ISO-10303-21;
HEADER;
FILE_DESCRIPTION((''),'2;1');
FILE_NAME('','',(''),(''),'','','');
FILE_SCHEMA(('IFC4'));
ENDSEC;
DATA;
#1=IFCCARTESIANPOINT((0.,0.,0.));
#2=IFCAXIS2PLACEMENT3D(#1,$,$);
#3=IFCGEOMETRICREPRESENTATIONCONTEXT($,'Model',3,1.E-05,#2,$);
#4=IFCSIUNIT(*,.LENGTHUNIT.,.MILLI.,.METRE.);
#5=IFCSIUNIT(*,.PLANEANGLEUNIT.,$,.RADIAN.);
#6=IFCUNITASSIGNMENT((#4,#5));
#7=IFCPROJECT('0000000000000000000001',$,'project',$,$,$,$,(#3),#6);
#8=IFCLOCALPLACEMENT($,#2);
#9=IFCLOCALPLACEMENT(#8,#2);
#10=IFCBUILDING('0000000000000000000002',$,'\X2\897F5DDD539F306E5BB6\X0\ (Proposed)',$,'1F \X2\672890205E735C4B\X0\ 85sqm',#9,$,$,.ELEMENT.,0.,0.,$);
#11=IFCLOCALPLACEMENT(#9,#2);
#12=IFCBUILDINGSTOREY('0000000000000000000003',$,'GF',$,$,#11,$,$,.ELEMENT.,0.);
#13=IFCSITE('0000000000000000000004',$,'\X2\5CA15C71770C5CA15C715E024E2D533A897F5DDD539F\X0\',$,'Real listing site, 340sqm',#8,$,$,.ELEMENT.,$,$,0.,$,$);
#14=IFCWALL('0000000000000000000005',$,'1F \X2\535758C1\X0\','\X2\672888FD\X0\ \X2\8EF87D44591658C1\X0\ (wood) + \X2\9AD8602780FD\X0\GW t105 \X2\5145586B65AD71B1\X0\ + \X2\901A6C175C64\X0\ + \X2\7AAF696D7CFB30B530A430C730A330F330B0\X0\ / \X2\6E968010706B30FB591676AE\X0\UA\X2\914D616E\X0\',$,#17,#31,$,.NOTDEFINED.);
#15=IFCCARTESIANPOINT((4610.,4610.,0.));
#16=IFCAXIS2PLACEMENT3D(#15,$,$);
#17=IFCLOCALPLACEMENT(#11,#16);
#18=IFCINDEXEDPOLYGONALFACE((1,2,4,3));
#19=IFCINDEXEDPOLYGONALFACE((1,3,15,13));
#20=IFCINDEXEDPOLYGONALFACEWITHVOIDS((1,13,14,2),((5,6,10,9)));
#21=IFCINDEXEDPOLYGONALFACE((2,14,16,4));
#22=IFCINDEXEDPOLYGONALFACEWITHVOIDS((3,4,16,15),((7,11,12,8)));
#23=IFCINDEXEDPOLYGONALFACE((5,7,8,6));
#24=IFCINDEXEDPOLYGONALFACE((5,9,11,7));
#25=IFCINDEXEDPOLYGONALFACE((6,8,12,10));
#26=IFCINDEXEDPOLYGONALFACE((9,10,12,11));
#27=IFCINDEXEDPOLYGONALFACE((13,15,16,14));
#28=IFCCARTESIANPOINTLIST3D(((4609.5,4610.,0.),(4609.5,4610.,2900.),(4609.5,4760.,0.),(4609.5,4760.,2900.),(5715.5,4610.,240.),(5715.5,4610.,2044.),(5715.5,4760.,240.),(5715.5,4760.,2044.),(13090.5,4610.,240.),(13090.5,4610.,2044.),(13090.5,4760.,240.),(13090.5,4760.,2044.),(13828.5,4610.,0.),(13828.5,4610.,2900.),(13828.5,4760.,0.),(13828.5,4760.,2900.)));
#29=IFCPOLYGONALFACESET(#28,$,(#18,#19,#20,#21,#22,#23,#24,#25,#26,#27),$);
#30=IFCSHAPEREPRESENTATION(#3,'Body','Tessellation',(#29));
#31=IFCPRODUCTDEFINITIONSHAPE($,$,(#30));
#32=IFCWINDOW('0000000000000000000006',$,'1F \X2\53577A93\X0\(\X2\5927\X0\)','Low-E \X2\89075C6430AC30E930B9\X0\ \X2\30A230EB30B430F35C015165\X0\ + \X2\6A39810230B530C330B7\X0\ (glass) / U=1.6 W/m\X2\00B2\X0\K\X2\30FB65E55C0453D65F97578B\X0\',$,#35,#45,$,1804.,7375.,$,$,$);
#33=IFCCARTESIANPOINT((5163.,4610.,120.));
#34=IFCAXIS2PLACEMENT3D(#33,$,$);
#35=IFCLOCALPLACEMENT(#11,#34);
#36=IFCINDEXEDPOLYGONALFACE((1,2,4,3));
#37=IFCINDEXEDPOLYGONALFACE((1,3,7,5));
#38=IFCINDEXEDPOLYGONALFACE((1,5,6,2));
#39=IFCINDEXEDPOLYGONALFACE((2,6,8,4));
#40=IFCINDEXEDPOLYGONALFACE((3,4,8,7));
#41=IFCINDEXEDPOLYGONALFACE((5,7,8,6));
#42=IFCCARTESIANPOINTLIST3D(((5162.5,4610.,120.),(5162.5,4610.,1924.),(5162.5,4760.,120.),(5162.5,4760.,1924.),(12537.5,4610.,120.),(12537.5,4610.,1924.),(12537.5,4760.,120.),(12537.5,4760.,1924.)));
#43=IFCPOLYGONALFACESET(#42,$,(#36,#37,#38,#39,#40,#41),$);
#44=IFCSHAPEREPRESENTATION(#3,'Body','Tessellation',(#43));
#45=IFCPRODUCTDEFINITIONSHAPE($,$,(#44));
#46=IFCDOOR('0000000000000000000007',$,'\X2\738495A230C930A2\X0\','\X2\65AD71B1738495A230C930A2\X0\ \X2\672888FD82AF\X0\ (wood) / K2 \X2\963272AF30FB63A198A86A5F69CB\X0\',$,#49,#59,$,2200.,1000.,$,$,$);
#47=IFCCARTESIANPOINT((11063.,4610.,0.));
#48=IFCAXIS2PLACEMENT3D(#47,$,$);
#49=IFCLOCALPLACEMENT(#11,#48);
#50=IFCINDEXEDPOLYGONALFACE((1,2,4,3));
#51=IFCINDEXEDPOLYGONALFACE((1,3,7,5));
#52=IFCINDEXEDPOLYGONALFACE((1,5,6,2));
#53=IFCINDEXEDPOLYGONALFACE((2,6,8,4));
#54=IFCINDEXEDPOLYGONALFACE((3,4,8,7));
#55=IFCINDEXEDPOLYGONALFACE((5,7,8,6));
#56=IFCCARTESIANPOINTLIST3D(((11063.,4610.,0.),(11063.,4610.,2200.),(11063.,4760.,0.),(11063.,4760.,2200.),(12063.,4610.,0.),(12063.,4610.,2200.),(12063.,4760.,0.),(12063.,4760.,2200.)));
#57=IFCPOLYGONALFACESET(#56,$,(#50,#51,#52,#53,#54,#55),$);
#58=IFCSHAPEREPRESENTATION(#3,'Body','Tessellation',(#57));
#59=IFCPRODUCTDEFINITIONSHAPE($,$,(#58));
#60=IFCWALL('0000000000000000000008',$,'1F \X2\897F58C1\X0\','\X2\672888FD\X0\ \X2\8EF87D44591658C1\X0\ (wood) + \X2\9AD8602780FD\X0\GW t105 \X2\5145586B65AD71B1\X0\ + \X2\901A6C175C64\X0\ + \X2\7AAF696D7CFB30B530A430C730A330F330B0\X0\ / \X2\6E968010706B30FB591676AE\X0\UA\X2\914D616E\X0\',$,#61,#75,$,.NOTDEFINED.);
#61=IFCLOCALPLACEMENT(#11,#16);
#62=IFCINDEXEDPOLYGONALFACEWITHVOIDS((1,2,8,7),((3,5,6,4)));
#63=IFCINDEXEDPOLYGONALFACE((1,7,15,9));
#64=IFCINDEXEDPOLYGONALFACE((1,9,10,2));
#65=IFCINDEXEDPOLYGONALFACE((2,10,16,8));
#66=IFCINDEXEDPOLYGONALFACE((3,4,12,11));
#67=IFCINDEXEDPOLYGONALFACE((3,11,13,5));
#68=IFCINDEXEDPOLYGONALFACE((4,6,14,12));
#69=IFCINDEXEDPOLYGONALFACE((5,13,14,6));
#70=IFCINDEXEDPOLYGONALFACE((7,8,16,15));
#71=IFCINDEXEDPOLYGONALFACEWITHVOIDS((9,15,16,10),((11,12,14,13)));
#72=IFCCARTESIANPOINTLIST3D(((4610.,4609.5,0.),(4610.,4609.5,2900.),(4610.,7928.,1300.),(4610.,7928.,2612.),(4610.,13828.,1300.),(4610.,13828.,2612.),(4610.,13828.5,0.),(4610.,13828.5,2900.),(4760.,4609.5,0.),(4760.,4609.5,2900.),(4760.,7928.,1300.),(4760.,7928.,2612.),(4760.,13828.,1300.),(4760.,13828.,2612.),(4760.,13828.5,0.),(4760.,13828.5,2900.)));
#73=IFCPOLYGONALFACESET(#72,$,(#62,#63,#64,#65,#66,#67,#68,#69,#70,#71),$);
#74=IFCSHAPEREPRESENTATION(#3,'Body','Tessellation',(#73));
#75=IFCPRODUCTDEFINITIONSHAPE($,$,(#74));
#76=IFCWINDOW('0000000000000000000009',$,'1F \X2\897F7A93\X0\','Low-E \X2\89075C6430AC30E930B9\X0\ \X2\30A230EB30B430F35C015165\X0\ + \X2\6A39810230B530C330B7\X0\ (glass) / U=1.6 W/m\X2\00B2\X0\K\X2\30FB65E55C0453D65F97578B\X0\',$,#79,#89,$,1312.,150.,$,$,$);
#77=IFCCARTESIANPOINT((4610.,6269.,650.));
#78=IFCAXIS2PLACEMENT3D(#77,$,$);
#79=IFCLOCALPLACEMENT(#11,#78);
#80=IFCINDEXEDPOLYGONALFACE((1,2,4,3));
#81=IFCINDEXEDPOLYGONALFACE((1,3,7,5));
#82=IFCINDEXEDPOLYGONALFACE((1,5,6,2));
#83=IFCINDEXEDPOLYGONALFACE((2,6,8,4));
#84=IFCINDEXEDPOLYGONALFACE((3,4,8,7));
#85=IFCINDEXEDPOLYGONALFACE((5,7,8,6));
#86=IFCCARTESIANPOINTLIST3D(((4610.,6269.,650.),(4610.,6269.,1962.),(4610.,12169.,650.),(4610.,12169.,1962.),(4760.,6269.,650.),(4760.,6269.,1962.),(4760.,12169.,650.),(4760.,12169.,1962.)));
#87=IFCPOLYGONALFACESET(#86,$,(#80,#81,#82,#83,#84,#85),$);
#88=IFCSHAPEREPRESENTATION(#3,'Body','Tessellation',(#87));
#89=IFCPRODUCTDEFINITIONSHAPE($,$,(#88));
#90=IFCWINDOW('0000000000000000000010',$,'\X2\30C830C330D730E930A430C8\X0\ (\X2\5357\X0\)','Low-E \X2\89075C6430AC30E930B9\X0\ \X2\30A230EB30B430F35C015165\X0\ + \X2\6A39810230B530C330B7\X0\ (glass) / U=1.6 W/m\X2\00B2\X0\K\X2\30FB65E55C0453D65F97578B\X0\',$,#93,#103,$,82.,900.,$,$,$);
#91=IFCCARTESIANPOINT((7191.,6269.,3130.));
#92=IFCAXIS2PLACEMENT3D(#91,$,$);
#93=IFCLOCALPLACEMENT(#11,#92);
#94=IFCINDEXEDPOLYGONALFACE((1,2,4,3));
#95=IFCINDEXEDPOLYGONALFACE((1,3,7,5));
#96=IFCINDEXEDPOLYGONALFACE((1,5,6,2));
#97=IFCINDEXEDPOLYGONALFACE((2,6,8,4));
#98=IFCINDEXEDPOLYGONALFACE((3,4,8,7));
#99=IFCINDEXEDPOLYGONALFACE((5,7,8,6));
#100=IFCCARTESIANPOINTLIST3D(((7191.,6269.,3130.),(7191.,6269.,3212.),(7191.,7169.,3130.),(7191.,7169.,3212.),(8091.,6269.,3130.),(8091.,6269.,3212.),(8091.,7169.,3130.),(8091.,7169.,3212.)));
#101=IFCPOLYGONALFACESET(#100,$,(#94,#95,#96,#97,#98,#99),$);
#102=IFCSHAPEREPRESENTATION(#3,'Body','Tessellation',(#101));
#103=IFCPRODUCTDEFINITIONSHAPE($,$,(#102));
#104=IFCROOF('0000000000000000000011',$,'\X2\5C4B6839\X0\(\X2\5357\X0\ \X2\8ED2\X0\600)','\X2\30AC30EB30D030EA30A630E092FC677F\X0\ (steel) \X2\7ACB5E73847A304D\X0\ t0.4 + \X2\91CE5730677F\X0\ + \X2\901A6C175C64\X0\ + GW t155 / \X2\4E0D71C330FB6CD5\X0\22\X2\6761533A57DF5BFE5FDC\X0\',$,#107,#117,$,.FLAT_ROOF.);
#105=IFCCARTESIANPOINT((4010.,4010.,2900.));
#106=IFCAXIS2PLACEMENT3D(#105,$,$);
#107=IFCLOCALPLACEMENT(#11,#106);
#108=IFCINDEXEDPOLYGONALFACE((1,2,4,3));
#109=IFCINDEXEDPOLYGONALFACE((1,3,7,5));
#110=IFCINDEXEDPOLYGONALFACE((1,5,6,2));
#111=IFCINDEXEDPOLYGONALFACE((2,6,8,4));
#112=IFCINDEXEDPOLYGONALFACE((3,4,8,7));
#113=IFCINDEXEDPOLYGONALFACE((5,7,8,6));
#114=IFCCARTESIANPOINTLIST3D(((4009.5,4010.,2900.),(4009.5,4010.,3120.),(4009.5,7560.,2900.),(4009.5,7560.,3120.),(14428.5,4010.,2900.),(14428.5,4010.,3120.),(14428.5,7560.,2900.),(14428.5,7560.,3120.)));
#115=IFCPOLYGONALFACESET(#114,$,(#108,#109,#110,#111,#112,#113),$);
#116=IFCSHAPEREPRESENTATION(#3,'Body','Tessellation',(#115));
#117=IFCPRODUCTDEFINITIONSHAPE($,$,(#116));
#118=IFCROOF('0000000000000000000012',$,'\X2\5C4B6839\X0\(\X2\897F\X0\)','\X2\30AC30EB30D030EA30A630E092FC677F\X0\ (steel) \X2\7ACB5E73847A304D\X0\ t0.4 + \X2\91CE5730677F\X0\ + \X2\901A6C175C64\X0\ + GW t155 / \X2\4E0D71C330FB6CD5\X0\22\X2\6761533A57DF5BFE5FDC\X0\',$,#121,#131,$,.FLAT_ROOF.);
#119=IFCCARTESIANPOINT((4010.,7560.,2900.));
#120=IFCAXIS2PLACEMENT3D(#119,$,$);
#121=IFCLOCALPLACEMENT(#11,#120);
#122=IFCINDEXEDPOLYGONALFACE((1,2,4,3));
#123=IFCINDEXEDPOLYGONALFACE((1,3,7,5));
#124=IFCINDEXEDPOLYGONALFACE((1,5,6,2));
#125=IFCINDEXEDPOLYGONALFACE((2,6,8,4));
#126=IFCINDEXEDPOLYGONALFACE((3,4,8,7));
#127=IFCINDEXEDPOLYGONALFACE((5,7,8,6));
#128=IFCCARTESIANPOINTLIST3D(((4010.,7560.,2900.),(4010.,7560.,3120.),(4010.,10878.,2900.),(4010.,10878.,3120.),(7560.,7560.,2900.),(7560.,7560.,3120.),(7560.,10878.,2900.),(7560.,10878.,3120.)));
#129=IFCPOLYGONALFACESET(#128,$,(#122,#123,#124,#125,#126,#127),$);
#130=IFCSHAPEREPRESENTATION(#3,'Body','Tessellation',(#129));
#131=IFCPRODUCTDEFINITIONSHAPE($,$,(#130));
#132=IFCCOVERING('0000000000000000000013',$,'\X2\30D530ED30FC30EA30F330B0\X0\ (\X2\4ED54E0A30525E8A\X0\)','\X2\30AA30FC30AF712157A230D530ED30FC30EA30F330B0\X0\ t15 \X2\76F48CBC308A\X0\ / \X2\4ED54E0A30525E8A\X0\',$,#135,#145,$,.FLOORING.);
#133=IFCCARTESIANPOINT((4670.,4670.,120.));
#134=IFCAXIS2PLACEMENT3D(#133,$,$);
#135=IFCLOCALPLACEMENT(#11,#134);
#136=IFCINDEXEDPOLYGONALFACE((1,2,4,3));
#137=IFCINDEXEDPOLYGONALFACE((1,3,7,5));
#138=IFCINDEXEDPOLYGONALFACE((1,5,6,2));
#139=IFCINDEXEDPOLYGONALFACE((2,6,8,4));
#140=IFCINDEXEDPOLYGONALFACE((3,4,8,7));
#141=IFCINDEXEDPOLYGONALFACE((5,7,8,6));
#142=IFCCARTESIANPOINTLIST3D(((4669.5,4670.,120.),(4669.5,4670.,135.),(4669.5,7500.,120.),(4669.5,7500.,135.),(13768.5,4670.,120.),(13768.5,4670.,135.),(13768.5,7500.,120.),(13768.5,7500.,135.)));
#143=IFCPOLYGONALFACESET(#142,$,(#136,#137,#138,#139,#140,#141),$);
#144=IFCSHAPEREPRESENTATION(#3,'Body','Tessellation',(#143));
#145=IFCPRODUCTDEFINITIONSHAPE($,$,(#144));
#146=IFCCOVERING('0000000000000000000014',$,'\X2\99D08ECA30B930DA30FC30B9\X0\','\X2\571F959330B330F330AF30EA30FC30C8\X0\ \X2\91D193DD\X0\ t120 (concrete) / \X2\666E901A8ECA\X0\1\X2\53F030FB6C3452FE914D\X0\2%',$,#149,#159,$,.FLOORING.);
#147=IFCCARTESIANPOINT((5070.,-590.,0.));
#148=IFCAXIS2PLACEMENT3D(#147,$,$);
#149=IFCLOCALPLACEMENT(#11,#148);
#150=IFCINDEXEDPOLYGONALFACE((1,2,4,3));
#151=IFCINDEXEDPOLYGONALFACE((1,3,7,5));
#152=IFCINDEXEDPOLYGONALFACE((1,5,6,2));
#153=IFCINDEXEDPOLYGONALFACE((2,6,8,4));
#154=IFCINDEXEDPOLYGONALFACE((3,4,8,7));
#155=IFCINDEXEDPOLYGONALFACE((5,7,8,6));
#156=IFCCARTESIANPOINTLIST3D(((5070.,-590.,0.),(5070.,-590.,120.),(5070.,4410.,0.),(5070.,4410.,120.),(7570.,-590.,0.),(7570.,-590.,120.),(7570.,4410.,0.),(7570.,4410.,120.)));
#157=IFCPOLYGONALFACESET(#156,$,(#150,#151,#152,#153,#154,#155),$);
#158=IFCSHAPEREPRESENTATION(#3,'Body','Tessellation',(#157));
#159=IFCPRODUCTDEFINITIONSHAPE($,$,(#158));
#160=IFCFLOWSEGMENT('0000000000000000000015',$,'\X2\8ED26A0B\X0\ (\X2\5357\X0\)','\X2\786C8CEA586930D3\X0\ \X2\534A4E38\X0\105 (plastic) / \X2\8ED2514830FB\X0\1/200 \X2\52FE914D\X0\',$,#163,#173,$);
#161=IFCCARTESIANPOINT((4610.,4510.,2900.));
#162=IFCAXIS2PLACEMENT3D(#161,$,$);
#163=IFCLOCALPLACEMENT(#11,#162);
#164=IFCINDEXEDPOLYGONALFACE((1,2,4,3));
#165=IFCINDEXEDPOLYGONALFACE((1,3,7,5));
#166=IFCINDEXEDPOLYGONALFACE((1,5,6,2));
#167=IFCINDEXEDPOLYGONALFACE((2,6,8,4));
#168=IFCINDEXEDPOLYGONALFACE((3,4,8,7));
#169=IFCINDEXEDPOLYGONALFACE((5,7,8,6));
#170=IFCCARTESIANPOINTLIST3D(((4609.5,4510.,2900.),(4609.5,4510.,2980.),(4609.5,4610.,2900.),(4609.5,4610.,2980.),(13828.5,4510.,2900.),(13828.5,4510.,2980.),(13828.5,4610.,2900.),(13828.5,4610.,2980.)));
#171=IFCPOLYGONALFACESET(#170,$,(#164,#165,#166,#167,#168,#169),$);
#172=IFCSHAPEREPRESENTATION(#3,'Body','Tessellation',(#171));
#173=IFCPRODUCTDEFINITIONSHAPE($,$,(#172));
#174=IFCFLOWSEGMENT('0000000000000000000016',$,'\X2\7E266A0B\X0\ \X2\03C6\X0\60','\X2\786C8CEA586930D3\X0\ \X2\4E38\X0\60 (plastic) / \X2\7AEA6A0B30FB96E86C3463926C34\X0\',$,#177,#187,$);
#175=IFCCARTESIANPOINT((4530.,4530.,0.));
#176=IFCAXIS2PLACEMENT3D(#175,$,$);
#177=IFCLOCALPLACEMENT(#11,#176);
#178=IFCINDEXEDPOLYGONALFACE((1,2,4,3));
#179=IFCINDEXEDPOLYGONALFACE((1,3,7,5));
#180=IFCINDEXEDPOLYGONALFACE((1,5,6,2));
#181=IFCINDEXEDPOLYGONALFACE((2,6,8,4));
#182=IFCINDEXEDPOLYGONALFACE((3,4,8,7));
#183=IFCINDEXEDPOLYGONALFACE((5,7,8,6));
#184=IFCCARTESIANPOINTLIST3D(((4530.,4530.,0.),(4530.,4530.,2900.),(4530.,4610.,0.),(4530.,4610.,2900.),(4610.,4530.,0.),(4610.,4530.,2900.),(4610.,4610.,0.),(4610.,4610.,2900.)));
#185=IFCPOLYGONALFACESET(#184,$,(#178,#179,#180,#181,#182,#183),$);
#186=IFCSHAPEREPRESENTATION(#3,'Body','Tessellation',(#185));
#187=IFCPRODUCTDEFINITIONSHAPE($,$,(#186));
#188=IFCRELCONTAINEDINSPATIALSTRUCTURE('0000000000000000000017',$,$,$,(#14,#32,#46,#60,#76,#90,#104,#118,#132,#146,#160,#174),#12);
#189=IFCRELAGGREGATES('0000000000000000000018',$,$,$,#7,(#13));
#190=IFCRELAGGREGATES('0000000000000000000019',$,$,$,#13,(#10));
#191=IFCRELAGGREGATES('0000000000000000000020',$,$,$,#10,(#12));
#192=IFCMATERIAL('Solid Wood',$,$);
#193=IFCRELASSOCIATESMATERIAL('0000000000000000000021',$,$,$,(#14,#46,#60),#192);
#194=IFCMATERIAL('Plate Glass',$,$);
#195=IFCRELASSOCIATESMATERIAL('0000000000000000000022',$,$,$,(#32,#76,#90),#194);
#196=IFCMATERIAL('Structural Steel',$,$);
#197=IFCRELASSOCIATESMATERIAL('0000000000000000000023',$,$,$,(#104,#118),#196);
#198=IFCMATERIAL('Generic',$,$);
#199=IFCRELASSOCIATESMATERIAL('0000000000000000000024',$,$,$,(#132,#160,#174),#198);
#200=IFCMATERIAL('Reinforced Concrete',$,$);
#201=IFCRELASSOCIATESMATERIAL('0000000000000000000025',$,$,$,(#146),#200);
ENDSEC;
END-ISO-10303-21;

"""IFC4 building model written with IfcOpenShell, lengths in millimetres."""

from ifc_helpers import new_model, si_unit, frame, frame_2d, origin, place, context, project, spatial, rectangle, extrude, material, element, fill, save


model = new_model("IFC4")

# Units and contexts
model_context = context("Model", 3, precision=1e-05, world=origin())
ifc_project = project(units=[si_unit("LENGTHUNIT", "METRE", prefix="MILLI"), si_unit("PLANEANGLEUNIT", "RADIAN")], contexts=[model_context])

# Site, building, storey
site_placement = place(None, origin())
site = spatial("IfcSite", under=ifc_project, at=site_placement, Name="岡山県岡山市中区西川原", ObjectType="Real listing site, 340sqm", CompositionType="ELEMENT", RefElevation=0.0)
building_placement = place(site_placement, origin())
building = spatial("IfcBuilding", under=site, at=building_placement, Name="西川原の家 (Proposed)", ObjectType="1F 木造平屋 85sqm", CompositionType="ELEMENT", ElevationOfRefHeight=0.0, ElevationOfTerrain=0.0)
storey_placement = place(building_placement, origin())
storey = spatial("IfcBuildingStorey", under=building, at=storey_placement, Name="GF", CompositionType="ELEMENT", Elevation=0.0)

# Shared definitions
ifc_material_1 = material(Name="Solid Wood")

# Shared definitions
ifc_material_2 = material(Name="Reinforced Concrete")

# Wall, openings, window, door
wall_1_placement = place(storey_placement, frame((4610.0, 4610.0, 0.0)))
wall_1 = element("IfcWall", 1, at=wall_1_placement, inside=storey, material=ifc_material_1, Name="1F 南壁", Description="木製 軸組外壁 (wood) + 高性能GW t105 充填断熱 + 通気層 + 窯業系サイディング / 準耐火・外皮UA配慮", PredefinedType="NOTDEFINED", context=model_context, shape_type="SweptSolid", body=[
    extrude(rectangle(XDim=9219.0, YDim=150.0, at=frame_2d((4609.0, 75.0))), frame((4610.0, 4610.0, 0.0)), (0.0, 0.0, 1.0), 2900.0),
])
opening_1_placement = place(storey_placement, frame((5163.0, 4610.0, 120.0)))
opening_1 = element("IfcOpeningElement", 2, at=opening_1_placement, cuts=wall_1, PredefinedType="NOTDEFINED", context=model_context, shape_type="SweptSolid", body=[
    extrude(rectangle(XDim=7375.0, YDim=150.0, at=frame_2d((3687.0, 75.0))), frame((5163.0, 4610.0, 120.0)), (0.0, 0.0, 1.0), 1804.0),
])
opening_2_placement = place(storey_placement, frame((11063.0, 4610.0, 0.0)))
opening_2 = element("IfcOpeningElement", 3, at=opening_2_placement, cuts=wall_1, PredefinedType="NOTDEFINED", context=model_context, shape_type="SweptSolid", body=[
    extrude(rectangle(XDim=1000.0, YDim=150.0, at=frame_2d((500.0, 75.0))), frame((11063.0, 4610.0, 0.0)), (0.0, 0.0, 1.0), 2200.0),
])
ifc_material_3 = material(Name="Plate Glass")
window_1_placement = place(storey_placement, frame((5163.0, 4610.0, 120.0)))
window_1 = element("IfcWindow", 4, at=window_1_placement, inside=storey, material=ifc_material_3, Name="1F 南窓(大)", Description="Low-E 複層ガラス アルゴン封入 + 樹脂サッシ (glass) / U=1.6 W/m²K・日射取得型", OverallHeight=1804.0, OverallWidth=7375.0, context=model_context, shape_type="SweptSolid", body=[
    extrude(rectangle(XDim=7375.0, YDim=150.0, at=frame_2d((3687.0, 75.0))), frame((5163.0, 4610.0, 120.0)), (0.0, 0.0, 1.0), 1804.0),
])
fill(opening_1, window_1)
door_placement = place(storey_placement, frame((11063.0, 4610.0, 0.0)))
door = element("IfcDoor", 5, at=door_placement, inside=storey, material=ifc_material_1, Name="玄関ドア", Description="断熱玄関ドア 木製芯 (wood) / K2 防犯・採風機構", OverallHeight=2200.0, OverallWidth=1000.0, context=model_context, shape_type="SweptSolid", body=[
    extrude(rectangle(XDim=1000.0, YDim=150.0, at=frame_2d((500.0, 75.0))), frame((11063.0, 4610.0, 0.0)), (0.0, 0.0, 1.0), 2200.0),
])
fill(opening_2, door)

# Wall, opening, window
wall_2_placement = place(storey_placement, frame((4610.0, 4610.0, 0.0)))
wall_2 = element("IfcWall", 6, at=wall_2_placement, inside=storey, material=ifc_material_1, Name="1F 西壁", Description="木製 軸組外壁 (wood) + 高性能GW t105 充填断熱 + 通気層 + 窯業系サイディング / 準耐火・外皮UA配慮", PredefinedType="NOTDEFINED", context=model_context, shape_type="SweptSolid", body=[
    extrude(rectangle(XDim=150.0, YDim=9219.0, at=frame_2d((75.0, 4609.0))), frame((4610.0, 4610.0, 0.0)), (0.0, 0.0, 1.0), 2900.0),
])
opening_3_placement = place(storey_placement, frame((4610.0, 6269.0, 650.0)))
opening_3 = element("IfcOpeningElement", 7, at=opening_3_placement, cuts=wall_2, PredefinedType="NOTDEFINED", context=model_context, shape_type="SweptSolid", body=[
    extrude(rectangle(XDim=150.0, YDim=5900.0, at=frame_2d((75.0, 2950.0))), frame((4610.0, 6269.0, 650.0)), (0.0, 0.0, 1.0), 1312.0),
])
window_2_placement = place(storey_placement, frame((4610.0, 6269.0, 650.0)))
window_2 = element("IfcWindow", 8, at=window_2_placement, inside=storey, material=ifc_material_3, Name="1F 西窓", Description="Low-E 複層ガラス アルゴン封入 + 樹脂サッシ (glass) / U=1.6 W/m²K・日射取得型", OverallHeight=1312.0, OverallWidth=150.0, context=model_context, shape_type="SweptSolid", body=[
    extrude(rectangle(XDim=150.0, YDim=5900.0, at=frame_2d((75.0, 2950.0))), frame((4610.0, 6269.0, 650.0)), (0.0, 0.0, 1.0), 1312.0),
])
fill(opening_3, window_2)

# Window
window_3_placement = place(storey_placement, frame((7191.0, 6269.0, 3130.0)))
element("IfcWindow", 9, at=window_3_placement, inside=storey, material=ifc_material_3, Name="トップライト (南)", Description="Low-E 複層ガラス アルゴン封入 + 樹脂サッシ (glass) / U=1.6 W/m²K・日射取得型", OverallHeight=82.0, OverallWidth=900.0, context=model_context, shape_type="SweptSolid", body=[
    extrude(rectangle(XDim=900.0, YDim=900.0, at=frame_2d((450.0, 450.0))), frame((7191.0, 6269.0, 3130.0)), (0.0, 0.0, 1.0), 82.0),
])

# Roofs
ifc_material_4 = material(Name="Structural Steel")
roof_1_placement = place(storey_placement, frame((4010.0, 4010.0, 2900.0)))
element("IfcRoof", 10, at=roof_1_placement, inside=storey, material=ifc_material_4, Name="屋根(南 軒600)", Description="ガルバリウム鋼板 (steel) 立平葺き t0.4 + 野地板 + 通気層 + GW t155 / 不燃・法22条区域対応", PredefinedType="FLAT_ROOF", context=model_context, shape_type="SweptSolid", body=[
    extrude(rectangle(XDim=10419.0, YDim=3550.0, at=frame_2d((5209.0, 1775.0))), frame((4010.0, 4010.0, 2900.0)), (0.0, 0.0, 1.0), 220.0),
])
roof_2_placement = place(storey_placement, frame((4010.0, 7560.0, 2900.0)))
element("IfcRoof", 11, at=roof_2_placement, inside=storey, material=ifc_material_4, Name="屋根(西)", Description="ガルバリウム鋼板 (steel) 立平葺き t0.4 + 野地板 + 通気層 + GW t155 / 不燃・法22条区域対応", PredefinedType="FLAT_ROOF", context=model_context, shape_type="SweptSolid", body=[
    extrude(rectangle(XDim=3550.0, YDim=3318.0, at=frame_2d((1775.0, 1659.0))), frame((4010.0, 7560.0, 2900.0)), (0.0, 0.0, 1.0), 220.0),
])

# Coverings
ifc_material_5 = material(Name="Generic")
covering_1_placement = place(storey_placement, frame((4670.0, 4670.0, 120.0)))
element("IfcCovering", 12, at=covering_1_placement, inside=storey, material=ifc_material_5, Name="フローリング (仕上げ床)", Description="オーク無垢フローリング t15 直貼り / 仕上げ床", PredefinedType="FLOORING", context=model_context, shape_type="SweptSolid", body=[
    extrude(rectangle(XDim=9099.0, YDim=2830.0, at=frame_2d((4549.0, 1415.0))), frame((4670.0, 4670.0, 120.0)), (0.0, 0.0, 1.0), 15.0),
])
covering_2_placement = place(storey_placement, frame((5070.0, -590.0, 0.0)))
element("IfcCovering", 13, at=covering_2_placement, inside=storey, material=ifc_material_2, Name="駐車スペース", Description="土間コンクリート 金鏝 t120 (concrete) / 普通車1台・水勾配2%", PredefinedType="FLOORING", context=model_context, shape_type="SweptSolid", body=[
    extrude(rectangle(XDim=2500.0, YDim=5000.0, at=frame_2d((1250.0, 2500.0))), frame((5070.0, -590.0, 0.0)), (0.0, 0.0, 1.0), 120.0),
])

# Flow segments
flow_segment_1_placement = place(storey_placement, frame((4610.0, 4510.0, 2900.0)))
element("IfcFlowSegment", 14, at=flow_segment_1_placement, inside=storey, material=ifc_material_5, Name="軒樋 (南)", Description="硬質塩ビ 半丸105 (plastic) / 軒先・1/200 勾配", context=model_context, shape_type="SweptSolid", body=[
    extrude(rectangle(XDim=9219.0, YDim=100.0, at=frame_2d((4609.0, 50.0))), frame((4610.0, 4510.0, 2900.0)), (0.0, 0.0, 1.0), 80.0),
])
flow_segment_2_placement = place(storey_placement, frame((4530.0, 4530.0, 0.0)))
element("IfcFlowSegment", 15, at=flow_segment_2_placement, inside=storey, material=ifc_material_5, Name="縦樋 φ60", Description="硬質塩ビ 丸60 (plastic) / 竪樋・雨水排水", context=model_context, shape_type="SweptSolid", body=[
    extrude(rectangle(XDim=80.0, YDim=80.0, at=frame_2d((40.0, 40.0))), frame((4530.0, 4530.0, 0.0)), (0.0, 0.0, 1.0), 2900.0),
])

save(model, "model.ifc")
